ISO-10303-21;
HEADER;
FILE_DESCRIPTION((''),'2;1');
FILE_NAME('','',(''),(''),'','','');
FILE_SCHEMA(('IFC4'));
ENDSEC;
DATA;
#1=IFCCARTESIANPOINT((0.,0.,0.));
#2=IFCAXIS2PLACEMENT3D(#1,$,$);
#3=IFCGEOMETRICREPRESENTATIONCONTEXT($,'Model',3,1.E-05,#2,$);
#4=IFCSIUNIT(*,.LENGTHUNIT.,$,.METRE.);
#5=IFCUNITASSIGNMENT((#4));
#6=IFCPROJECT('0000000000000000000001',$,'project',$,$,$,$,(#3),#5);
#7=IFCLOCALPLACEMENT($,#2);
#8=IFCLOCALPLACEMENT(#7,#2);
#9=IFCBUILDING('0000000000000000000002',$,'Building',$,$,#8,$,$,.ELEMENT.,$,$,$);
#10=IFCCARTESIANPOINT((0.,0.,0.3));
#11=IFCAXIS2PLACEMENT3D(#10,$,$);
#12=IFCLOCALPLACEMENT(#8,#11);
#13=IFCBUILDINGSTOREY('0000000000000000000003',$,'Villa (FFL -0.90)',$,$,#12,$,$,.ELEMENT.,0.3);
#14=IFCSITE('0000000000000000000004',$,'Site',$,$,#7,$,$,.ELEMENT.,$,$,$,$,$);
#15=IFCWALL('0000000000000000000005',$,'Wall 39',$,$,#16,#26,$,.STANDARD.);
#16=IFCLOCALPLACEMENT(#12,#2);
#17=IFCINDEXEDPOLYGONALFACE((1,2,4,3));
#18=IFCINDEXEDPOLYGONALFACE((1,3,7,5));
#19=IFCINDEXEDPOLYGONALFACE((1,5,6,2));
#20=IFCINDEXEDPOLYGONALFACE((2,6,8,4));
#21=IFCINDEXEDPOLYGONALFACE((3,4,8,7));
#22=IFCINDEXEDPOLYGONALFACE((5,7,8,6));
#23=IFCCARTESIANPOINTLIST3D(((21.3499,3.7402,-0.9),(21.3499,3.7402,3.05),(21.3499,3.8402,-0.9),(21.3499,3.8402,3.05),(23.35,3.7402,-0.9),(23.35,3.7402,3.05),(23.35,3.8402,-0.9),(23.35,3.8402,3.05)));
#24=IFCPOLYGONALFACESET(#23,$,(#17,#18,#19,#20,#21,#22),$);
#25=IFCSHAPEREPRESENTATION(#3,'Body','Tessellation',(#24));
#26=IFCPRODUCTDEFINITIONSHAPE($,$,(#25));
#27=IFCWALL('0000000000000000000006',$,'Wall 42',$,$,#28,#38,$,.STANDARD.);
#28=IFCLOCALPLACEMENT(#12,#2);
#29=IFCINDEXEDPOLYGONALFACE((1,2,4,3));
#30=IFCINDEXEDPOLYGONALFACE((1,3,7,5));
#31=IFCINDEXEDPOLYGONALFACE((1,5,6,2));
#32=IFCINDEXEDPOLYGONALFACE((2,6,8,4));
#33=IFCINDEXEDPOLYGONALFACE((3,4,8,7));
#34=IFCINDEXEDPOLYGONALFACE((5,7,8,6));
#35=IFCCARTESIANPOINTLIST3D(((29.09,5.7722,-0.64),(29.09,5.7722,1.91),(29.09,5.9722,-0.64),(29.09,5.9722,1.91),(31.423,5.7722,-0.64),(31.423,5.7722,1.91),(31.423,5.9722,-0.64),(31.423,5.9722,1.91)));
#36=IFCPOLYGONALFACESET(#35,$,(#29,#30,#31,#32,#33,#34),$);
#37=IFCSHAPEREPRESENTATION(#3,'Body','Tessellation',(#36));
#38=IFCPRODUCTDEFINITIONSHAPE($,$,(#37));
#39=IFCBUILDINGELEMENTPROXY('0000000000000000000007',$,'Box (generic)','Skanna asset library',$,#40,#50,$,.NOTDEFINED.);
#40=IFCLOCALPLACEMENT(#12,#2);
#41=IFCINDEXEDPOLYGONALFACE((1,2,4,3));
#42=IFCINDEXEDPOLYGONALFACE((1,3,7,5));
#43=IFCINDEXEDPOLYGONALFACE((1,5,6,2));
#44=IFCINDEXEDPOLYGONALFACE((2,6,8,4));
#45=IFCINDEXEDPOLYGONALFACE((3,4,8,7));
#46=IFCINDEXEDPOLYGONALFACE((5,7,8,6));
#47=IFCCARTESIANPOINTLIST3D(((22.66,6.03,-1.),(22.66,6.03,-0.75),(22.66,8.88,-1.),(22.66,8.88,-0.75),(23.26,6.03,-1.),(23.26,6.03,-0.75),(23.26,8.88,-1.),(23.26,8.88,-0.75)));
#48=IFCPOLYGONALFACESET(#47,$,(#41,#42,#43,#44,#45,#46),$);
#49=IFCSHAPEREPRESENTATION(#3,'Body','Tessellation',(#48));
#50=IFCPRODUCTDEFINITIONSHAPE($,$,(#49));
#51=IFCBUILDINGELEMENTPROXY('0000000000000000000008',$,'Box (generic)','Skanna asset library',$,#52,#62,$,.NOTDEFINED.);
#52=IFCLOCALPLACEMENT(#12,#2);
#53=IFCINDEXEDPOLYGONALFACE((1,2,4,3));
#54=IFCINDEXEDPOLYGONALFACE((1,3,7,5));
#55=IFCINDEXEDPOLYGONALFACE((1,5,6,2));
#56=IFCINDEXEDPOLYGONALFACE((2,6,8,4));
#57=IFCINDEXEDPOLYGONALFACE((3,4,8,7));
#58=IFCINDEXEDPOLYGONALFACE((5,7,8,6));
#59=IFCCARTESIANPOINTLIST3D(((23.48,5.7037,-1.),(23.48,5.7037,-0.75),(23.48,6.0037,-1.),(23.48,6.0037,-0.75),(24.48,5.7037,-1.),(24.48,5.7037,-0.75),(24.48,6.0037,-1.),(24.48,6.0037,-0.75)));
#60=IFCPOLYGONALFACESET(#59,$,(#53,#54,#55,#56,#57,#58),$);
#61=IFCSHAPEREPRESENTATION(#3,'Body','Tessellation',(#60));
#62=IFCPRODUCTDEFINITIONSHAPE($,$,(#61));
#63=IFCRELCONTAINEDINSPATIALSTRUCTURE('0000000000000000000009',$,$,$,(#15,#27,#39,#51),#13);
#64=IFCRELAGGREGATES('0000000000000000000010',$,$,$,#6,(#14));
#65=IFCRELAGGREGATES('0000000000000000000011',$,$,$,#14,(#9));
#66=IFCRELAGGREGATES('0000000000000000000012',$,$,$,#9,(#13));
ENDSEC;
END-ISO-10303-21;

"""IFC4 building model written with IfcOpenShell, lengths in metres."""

from ifc_helpers import new_model, si_unit, frame, frame_2d, origin, origin_2d, place, context, project, spatial, rectangle, extrude, element, save


model = new_model("IFC4")

# Units and contexts
model_context = context("Model", 3, precision=1e-05, world=origin())
ifc_project = project(units=[si_unit("LENGTHUNIT", "METRE")], contexts=[model_context])

# Site, building, storey
site_placement = place(None, origin())
site = spatial("IfcSite", under=ifc_project, at=site_placement, Name="Site", CompositionType="ELEMENT")
building_placement = place(site_placement, origin())
building = spatial("IfcBuilding", under=site, at=building_placement, Name="Building", CompositionType="ELEMENT")
storey_placement = place(building_placement, frame((0.0, 0.0, 0.3)))
storey = spatial("IfcBuildingStorey", under=building, at=storey_placement, Name="Villa (FFL -0.90)", CompositionType="ELEMENT", Elevation=0.3)

# Walls
wall_1_placement = place(storey_placement, frame((21.3499, 3.7902, -0.9), z_axis=(0.0, 0.0, 1.0), x_axis=(1.0, 0.0, 0.0)))
element("IfcWall", 1, at=wall_1_placement, inside=storey, Name="Wall 39", PredefinedType="STANDARD", context=model_context, shape_type="SweptSolid", body=[
    extrude(rectangle(XDim=2.0001, YDim=0.1, at=frame_2d((1.0001, 0.0))), origin(), (0.0, 0.0, 1.0), 3.95),
])
wall_2_placement = place(storey_placement, frame((31.423, 5.8722, -0.64), z_axis=(0.0, 0.0, 1.0), x_axis=(-1.0, 0.0, 0.0)))
element("IfcWall", 2, at=wall_2_placement, inside=storey, Name="Wall 42", PredefinedType="STANDARD", context=model_context, shape_type="SweptSolid", body=[
    extrude(rectangle(XDim=2.333, YDim=0.2, at=frame_2d((1.1665, 0.0))), origin(), (0.0, 0.0, 1.0), 2.55),
])

# Building element proxies
proxy_1_placement = place(storey_placement, frame((22.96, 7.455, -1.0), z_axis=(0.0, 0.0, 1.0), x_axis=(0.0, 1.0, 0.0)))
element("IfcBuildingElementProxy", 3, at=proxy_1_placement, inside=storey, Name="Box (generic)", Description="Skanna asset library", PredefinedType="NOTDEFINED", context=model_context, shape_type="SweptSolid", body=[
    extrude(rectangle(XDim=2.85, YDim=0.6, at=origin_2d()), origin(), (0.0, 0.0, 1.0), 0.25),
])
proxy_2_placement = place(storey_placement, frame((23.98, 5.8537, -1.0), z_axis=(0.0, 0.0, 1.0), x_axis=(-1.0, 0.0, 0.0)))
element("IfcBuildingElementProxy", 4, at=proxy_2_placement, inside=storey, Name="Box (generic)", Description="Skanna asset library", PredefinedType="NOTDEFINED", context=model_context, shape_type="SweptSolid", body=[
    extrude(rectangle(XDim=1.0, YDim=0.3, at=origin_2d()), origin(), (0.0, 0.0, 1.0), 0.25),
])

save(model, "model.ifc")
